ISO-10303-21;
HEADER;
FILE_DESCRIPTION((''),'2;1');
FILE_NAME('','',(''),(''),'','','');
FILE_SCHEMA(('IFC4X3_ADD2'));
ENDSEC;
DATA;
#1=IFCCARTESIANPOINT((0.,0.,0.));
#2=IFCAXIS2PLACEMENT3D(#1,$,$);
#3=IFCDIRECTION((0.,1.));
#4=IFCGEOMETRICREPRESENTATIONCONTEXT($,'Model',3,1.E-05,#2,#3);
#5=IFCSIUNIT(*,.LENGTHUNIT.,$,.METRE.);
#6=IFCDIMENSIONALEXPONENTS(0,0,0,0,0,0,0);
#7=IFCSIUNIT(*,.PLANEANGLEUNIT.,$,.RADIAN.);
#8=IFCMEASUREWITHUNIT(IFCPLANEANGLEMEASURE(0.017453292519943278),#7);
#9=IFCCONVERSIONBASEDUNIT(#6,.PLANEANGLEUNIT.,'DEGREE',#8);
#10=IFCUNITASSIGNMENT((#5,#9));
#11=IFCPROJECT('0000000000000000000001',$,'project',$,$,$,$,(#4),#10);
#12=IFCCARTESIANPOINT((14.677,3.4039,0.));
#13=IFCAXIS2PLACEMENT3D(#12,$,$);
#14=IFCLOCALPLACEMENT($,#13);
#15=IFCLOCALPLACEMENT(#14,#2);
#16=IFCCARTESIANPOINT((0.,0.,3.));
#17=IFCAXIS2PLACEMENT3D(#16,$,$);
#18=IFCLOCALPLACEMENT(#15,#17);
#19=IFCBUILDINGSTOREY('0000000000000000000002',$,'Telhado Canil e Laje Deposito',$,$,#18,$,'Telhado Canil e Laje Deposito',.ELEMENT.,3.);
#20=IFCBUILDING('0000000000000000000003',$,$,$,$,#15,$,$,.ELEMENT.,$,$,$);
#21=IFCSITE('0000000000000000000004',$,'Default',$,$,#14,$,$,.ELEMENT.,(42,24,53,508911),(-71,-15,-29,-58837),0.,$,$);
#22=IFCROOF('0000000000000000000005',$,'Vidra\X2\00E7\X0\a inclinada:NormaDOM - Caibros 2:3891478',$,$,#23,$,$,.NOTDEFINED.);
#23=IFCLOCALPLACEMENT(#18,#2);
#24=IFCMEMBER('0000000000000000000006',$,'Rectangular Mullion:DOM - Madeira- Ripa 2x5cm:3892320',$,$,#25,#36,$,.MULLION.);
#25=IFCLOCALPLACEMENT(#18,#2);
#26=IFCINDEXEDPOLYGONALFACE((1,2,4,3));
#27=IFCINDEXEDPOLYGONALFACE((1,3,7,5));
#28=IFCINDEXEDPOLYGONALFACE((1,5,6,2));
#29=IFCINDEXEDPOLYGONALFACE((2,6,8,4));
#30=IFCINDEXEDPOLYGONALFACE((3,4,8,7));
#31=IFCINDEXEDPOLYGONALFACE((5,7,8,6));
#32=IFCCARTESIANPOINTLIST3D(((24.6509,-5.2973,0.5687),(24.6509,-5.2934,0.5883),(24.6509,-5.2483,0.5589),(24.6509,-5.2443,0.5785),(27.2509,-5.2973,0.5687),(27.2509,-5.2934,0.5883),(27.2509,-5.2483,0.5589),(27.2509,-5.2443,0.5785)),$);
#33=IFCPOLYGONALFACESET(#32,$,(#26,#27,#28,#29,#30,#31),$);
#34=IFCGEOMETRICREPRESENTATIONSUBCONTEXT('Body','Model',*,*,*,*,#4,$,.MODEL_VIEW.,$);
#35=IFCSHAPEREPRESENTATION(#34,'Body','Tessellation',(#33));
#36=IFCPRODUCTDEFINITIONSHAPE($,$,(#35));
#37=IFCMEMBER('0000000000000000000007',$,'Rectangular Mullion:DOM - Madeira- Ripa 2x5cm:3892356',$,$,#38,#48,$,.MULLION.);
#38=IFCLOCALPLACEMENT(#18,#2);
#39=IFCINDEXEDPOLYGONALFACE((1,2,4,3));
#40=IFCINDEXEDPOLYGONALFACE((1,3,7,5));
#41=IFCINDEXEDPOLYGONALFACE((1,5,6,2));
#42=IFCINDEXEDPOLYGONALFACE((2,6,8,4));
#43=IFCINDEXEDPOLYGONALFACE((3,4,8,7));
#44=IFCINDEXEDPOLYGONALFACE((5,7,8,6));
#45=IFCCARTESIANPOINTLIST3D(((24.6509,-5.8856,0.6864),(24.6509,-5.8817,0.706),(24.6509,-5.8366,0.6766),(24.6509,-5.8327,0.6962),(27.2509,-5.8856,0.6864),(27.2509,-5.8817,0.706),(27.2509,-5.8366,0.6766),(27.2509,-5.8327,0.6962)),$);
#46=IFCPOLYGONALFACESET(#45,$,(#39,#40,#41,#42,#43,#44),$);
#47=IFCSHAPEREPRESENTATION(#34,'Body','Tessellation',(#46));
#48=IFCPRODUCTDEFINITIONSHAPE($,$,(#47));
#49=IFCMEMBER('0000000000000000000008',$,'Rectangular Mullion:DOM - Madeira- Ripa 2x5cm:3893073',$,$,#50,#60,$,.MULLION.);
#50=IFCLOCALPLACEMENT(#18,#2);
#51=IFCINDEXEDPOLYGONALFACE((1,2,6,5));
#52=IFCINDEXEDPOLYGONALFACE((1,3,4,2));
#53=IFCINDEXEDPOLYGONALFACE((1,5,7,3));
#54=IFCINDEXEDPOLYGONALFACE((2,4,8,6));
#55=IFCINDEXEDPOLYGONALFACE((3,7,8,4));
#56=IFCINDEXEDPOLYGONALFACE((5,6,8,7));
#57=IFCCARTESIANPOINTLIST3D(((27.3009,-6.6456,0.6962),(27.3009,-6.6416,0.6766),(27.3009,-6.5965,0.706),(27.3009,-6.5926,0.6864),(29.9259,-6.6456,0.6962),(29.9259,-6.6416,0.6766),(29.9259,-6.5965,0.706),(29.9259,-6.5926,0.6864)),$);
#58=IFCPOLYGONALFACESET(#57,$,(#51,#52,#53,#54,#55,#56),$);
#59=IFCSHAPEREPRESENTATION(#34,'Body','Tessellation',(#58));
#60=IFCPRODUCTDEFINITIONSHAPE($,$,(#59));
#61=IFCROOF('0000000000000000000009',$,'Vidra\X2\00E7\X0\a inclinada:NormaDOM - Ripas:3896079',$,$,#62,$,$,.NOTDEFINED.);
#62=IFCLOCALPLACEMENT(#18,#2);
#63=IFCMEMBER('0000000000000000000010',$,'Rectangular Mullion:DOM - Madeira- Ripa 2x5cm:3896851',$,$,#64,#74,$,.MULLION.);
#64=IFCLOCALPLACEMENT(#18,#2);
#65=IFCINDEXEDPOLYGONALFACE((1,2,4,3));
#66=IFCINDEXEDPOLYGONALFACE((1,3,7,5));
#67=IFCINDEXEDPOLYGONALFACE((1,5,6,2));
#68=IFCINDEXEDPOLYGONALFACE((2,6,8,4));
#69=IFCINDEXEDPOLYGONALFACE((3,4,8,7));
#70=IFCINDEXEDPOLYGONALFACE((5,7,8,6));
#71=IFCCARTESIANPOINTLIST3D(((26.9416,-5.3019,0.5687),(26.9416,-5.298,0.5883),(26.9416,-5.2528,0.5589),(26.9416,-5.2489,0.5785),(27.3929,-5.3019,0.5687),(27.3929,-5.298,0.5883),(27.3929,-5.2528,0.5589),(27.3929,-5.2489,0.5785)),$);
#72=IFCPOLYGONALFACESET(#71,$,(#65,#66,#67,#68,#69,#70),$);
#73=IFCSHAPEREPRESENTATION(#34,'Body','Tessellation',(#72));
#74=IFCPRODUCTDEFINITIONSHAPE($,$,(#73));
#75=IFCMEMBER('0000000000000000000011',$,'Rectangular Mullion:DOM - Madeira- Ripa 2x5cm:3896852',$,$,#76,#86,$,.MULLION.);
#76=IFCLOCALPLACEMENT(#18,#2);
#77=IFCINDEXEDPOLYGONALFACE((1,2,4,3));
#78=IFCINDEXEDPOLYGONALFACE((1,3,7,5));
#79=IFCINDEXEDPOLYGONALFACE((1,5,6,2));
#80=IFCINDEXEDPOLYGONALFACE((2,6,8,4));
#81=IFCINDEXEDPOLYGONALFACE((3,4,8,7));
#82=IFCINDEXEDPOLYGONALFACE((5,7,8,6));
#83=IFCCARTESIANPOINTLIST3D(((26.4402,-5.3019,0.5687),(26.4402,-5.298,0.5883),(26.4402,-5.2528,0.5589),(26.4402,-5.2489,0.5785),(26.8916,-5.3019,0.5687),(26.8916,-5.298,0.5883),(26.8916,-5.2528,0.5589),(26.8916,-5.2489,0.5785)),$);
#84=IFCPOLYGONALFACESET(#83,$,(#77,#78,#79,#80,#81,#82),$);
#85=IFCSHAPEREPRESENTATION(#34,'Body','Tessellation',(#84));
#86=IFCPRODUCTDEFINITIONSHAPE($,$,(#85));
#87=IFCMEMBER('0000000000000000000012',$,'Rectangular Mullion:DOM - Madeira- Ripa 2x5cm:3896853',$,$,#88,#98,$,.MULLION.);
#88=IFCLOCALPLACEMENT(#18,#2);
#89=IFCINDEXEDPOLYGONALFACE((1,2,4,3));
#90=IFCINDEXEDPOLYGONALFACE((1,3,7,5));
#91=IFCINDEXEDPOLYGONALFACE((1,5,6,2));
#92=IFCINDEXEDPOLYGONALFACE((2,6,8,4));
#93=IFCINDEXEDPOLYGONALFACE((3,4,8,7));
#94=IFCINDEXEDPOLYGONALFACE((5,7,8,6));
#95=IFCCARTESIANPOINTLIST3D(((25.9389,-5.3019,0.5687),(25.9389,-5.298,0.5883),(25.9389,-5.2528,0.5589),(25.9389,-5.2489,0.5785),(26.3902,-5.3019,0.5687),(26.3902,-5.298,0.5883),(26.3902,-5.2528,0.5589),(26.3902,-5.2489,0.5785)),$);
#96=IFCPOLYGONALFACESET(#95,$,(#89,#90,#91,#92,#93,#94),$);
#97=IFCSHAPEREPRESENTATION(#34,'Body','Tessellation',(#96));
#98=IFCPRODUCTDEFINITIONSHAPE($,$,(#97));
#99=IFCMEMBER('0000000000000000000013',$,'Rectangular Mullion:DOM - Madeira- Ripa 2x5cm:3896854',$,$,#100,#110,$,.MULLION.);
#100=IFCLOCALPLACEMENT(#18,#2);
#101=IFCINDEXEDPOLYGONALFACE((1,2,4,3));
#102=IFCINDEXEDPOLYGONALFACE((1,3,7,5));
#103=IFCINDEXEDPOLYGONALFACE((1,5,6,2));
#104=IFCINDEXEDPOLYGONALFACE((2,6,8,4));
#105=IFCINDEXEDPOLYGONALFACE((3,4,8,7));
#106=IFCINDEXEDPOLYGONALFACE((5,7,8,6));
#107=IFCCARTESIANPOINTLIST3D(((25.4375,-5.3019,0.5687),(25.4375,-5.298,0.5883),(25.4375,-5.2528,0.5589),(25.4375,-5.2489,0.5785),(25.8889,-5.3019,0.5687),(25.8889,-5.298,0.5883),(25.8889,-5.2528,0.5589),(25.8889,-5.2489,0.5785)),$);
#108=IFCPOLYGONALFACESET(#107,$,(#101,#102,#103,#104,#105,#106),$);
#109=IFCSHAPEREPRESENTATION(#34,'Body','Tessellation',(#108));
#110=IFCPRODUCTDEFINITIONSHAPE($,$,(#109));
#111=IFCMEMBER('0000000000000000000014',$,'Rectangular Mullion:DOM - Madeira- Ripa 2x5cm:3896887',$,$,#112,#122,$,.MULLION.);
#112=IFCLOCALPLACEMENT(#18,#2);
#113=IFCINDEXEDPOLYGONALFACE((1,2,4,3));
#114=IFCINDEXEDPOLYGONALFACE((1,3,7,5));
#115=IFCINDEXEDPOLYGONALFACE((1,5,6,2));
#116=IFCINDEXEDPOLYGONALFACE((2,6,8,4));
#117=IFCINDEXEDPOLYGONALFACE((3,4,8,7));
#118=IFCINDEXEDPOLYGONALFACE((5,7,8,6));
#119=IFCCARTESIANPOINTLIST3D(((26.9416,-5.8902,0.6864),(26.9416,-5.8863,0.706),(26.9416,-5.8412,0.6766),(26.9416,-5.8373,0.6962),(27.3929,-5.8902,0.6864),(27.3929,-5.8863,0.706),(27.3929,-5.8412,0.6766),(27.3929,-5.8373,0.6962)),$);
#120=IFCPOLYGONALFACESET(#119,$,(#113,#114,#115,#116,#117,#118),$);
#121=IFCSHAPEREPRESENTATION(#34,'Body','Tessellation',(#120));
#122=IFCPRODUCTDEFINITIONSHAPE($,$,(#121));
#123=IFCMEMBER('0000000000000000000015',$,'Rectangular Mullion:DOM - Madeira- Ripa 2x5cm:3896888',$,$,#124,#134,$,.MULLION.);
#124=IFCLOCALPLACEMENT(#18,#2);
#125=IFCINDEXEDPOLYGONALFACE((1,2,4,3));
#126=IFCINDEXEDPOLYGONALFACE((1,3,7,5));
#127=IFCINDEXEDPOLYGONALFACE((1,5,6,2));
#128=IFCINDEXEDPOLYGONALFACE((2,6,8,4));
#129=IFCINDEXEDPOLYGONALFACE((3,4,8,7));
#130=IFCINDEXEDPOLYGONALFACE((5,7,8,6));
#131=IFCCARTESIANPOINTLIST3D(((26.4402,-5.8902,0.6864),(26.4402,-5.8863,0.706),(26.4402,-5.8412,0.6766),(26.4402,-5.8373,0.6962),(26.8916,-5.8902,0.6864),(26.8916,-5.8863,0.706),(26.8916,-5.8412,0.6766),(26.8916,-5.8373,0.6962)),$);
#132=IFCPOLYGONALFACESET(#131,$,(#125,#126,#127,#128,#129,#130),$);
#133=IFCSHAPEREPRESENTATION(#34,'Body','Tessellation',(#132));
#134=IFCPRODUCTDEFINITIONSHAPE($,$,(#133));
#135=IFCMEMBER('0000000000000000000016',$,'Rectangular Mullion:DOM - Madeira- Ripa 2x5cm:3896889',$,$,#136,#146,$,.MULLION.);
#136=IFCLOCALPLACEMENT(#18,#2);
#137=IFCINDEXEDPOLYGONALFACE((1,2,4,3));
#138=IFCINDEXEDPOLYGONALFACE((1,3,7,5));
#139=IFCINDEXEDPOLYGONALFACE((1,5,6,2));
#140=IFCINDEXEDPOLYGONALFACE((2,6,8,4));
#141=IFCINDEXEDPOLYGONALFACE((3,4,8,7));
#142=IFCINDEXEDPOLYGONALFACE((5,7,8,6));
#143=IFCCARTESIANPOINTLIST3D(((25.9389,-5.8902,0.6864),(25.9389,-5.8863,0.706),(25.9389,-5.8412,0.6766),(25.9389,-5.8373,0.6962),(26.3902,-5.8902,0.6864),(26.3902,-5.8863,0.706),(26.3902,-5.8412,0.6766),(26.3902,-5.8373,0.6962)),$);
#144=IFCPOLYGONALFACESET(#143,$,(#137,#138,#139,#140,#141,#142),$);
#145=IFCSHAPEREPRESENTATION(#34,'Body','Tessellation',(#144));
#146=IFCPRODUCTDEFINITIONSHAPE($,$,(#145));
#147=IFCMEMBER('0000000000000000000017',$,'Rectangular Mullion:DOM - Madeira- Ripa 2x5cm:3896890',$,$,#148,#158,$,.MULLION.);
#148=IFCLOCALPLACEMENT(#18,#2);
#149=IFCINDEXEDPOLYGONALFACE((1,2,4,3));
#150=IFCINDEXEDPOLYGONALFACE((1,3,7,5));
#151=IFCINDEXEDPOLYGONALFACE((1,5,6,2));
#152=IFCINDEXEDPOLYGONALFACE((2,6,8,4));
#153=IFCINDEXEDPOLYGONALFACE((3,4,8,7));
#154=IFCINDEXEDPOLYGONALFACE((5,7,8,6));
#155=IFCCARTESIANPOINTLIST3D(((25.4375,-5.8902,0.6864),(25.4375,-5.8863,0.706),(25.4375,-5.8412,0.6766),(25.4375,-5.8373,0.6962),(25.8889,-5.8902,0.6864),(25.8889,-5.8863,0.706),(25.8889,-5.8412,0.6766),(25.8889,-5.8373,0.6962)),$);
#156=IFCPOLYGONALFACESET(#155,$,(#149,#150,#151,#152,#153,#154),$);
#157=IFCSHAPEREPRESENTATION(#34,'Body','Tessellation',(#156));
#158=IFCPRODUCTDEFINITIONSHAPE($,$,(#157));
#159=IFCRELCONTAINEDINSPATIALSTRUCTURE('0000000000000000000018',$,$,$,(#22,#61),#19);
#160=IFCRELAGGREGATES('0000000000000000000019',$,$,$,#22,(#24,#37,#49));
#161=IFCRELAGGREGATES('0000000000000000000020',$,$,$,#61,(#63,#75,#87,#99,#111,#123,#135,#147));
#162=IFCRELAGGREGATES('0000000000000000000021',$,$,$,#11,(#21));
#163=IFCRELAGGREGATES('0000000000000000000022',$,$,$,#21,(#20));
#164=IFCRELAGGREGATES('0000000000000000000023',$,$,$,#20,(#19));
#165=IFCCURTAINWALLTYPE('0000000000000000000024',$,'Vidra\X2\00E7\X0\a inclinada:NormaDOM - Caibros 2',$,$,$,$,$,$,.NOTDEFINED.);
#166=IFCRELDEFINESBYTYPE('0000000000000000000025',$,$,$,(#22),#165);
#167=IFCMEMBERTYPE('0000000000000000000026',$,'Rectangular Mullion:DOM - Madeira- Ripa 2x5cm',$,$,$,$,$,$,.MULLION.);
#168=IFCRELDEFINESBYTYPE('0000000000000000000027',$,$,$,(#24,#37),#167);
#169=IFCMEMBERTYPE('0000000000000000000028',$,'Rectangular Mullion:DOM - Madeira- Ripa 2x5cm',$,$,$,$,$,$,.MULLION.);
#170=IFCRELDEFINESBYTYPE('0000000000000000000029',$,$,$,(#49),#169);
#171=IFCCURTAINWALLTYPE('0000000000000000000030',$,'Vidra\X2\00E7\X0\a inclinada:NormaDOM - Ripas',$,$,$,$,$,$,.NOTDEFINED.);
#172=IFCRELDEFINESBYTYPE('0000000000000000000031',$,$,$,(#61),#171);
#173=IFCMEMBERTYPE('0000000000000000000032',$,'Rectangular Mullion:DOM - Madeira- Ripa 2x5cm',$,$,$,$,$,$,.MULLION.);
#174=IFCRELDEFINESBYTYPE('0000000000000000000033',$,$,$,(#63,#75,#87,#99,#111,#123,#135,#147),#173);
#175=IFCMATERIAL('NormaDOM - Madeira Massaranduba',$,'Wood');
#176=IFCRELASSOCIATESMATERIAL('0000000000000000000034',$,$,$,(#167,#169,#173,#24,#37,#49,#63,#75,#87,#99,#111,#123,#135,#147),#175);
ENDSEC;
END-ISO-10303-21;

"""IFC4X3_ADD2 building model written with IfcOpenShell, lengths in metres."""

from ifc_helpers import new_model, entity, si_unit, converted_unit, direction, frame, origin, origin_2d_with_axis, place, context, subcontext, project, spatial, rectangle, extrude, source, transform, mapped, material, material_profile, profile_set, profile_usage, type_object, type_shapes, element, aggregate, save


model = new_model("IFC4X3_ADD2")

# Units and contexts
model_context = context("Model", 3, precision=1e-05, world=origin(), true_north=direction((0.0, 1.0)))
body_context = subcontext(model_context, "Body", "Model", "MODEL_VIEW")
ifc_project = project(units=[si_unit("LENGTHUNIT", "METRE"), converted_unit("PLANEANGLEUNIT", "DEGREE", entity("IfcPlaneAngleMeasure", 0.017453292519943278), si_unit("PLANEANGLEUNIT", "RADIAN"), dimensions=[0, 0, 0, 0, 0, 0, 0])], contexts=[model_context])

# Site, building, storey
site_placement = place(None, frame((14.677, 3.4039, 0.0)))
site = spatial("IfcSite", under=ifc_project, at=site_placement, Name="Default", CompositionType="ELEMENT", RefLatitude=(42, 24, 53, 508911), RefLongitude=(-71, -15, -29, -58837), RefElevation=0.0)
building_placement = place(site_placement, origin())
building = spatial("IfcBuilding", under=site, at=building_placement, CompositionType="ELEMENT")
storey_placement = place(building_placement, frame((0.0, 0.0, 3.0)))
storey = spatial("IfcBuildingStorey", under=building, at=storey_placement, Name="Telhado Canil e Laje Deposito", LongName="Telhado Canil e Laje Deposito", CompositionType="ELEMENT", Elevation=3.0)

# Roofs, members
curtain_wall_type_1 = type_object("IfcCurtainWallType", Name="Vidraça inclinada:NormaDOM - Caibros 2", PredefinedType="NOTDEFINED")
roof_1_placement = place(storey_placement, frame((0.0, 0.0, -3.0)))
roof_1 = element("IfcRoof", 1, at=roof_1_placement, inside=storey, type_object=curtain_wall_type_1, Name="Vidraça inclinada:NormaDOM - Caibros 2:3891478", PredefinedType="NOTDEFINED")
ifc_material = material(Name="NormaDOM - Madeira Massaranduba", Category="Wood")
ifc_material_profile_1 = material_profile(ifc_material, rectangle(XDim=0.05, YDim=0.02, at=origin_2d_with_axis()), Name="DOM - Madeira- Ripa 2x5cm")
ifc_profile_set_1 = profile_set([ifc_material_profile_1], Name="DOM - Madeira- Ripa 2x5cm")
ifc_profile_usage_1 = profile_usage(ifc_profile_set_1)
member_type_1 = type_object("IfcMemberType", Name="Rectangular Mullion:DOM - Madeira- Ripa 2x5cm", PredefinedType="MULLION", material=ifc_profile_set_1)
shared_shape_1 = source(origin(), body_context, "Body", "SweptSolid", [
    extrude(rectangle(XDim=0.05, YDim=0.02, at=origin_2d_with_axis()), frame((0.025, 0.01, -2.6), z_axis=(0.0, 0.0, 1.0), x_axis=(-1.0, 0.0, 0.0)), (0.0, 0.0, 1.0), 2.6),
])
type_shapes(member_type_1, [shared_shape_1])
member_1_placement = place(roof_1_placement, frame((27.2509, -5.2443, 3.5785), z_axis=(1.0, 0.0, 0.0), x_axis=(0.0, -0.980581, 0.196116)))
member_1 = element("IfcMember", 2, at=member_1_placement, type_object=member_type_1, material=ifc_profile_usage_1, Name="Rectangular Mullion:DOM - Madeira- Ripa 2x5cm:3892320", PredefinedType="MULLION", context=body_context, shape_type="MappedRepresentation", body=[
    mapped(shared_shape_1, transform((0.0, 0.0, 0.0), scale=1.0)),
])
member_2_placement = place(roof_1_placement, frame((27.2509, -5.8327, 3.6962), z_axis=(1.0, 0.0, 0.0), x_axis=(0.0, -0.980581, 0.196116)))
member_2 = element("IfcMember", 3, at=member_2_placement, type_object=member_type_1, material=ifc_profile_usage_1, Name="Rectangular Mullion:DOM - Madeira- Ripa 2x5cm:3892356", PredefinedType="MULLION", context=body_context, shape_type="MappedRepresentation", body=[
    mapped(shared_shape_1, transform((0.0, 0.0, 0.0), scale=1.0)),
])
member_type_2 = type_object("IfcMemberType", Name="Rectangular Mullion:DOM - Madeira- Ripa 2x5cm", PredefinedType="MULLION", material=ifc_profile_set_1)
shared_shape_2 = source(origin(), body_context, "Body", "SweptSolid", [
    extrude(rectangle(XDim=0.05, YDim=0.02, at=origin_2d_with_axis()), frame((0.025, 0.01, -2.625), z_axis=(0.0, 0.0, 1.0), x_axis=(-1.0, 0.0, 0.0)), (0.0, 0.0, 1.0), 2.625),
])
type_shapes(member_type_2, [shared_shape_2])
member_3_placement = place(roof_1_placement, frame((27.3009, -6.6456, 3.6962), z_axis=(-1.0, 0.0, 0.0), x_axis=(0.0, 0.980581, 0.196116)))
member_3 = element("IfcMember", 4, at=member_3_placement, type_object=member_type_2, material=ifc_profile_usage_1, Name="Rectangular Mullion:DOM - Madeira- Ripa 2x5cm:3893073", PredefinedType="MULLION", context=body_context, shape_type="MappedRepresentation", body=[
    mapped(shared_shape_2, transform((0.0, 0.0, 0.0), scale=1.0)),
])
curtain_wall_type_2 = type_object("IfcCurtainWallType", Name="Vidraça inclinada:NormaDOM - Ripas", PredefinedType="NOTDEFINED")
roof_2_placement = place(storey_placement, frame((0.0, 0.0, -3.0)))
roof_2 = element("IfcRoof", 5, at=roof_2_placement, inside=storey, type_object=curtain_wall_type_2, Name="Vidraça inclinada:NormaDOM - Ripas:3896079", PredefinedType="NOTDEFINED")

# Members
aggregate(roof_1, [member_1, member_2, member_3])
member_type_3 = type_object("IfcMemberType", Name="Rectangular Mullion:DOM - Madeira- Ripa 2x5cm", PredefinedType="MULLION", material=ifc_profile_set_1)
shared_shape_3 = source(origin(), body_context, "Body", "SweptSolid", [
    extrude(rectangle(XDim=0.05, YDim=0.02, at=origin_2d_with_axis()), frame((0.025, 0.01, -0.4514), z_axis=(0.0, 0.0, 1.0), x_axis=(-1.0, 0.0, 0.0)), (0.0, 0.0, 1.0), 0.4514),
])
type_shapes(member_type_3, [shared_shape_3])
member_4_placement = place(roof_2_placement, frame((27.3929, -5.2489, 3.5785), z_axis=(1.0, 0.0, 0.0), x_axis=(0.0, -0.980581, 0.196116)))
member_4 = element("IfcMember", 6, at=member_4_placement, type_object=member_type_3, material=ifc_profile_usage_1, Name="Rectangular Mullion:DOM - Madeira- Ripa 2x5cm:3896851", PredefinedType="MULLION", context=body_context, shape_type="MappedRepresentation", body=[
    mapped(shared_shape_3, transform((0.0, 0.0, 0.0), scale=1.0)),
])
member_5_placement = place(roof_2_placement, frame((26.8916, -5.2489, 3.5785), z_axis=(1.0, 0.0, 0.0), x_axis=(0.0, -0.980581, 0.196116)))
member_5 = element("IfcMember", 7, at=member_5_placement, type_object=member_type_3, material=ifc_profile_usage_1, Name="Rectangular Mullion:DOM - Madeira- Ripa 2x5cm:3896852", PredefinedType="MULLION", context=body_context, shape_type="MappedRepresentation", body=[
    mapped(shared_shape_3, transform((0.0, 0.0, 0.0), scale=1.0)),
])
member_6_placement = place(roof_2_placement, frame((26.3902, -5.2489, 3.5785), z_axis=(1.0, 0.0, 0.0), x_axis=(0.0, -0.980581, 0.196116)))
member_6 = element("IfcMember", 8, at=member_6_placement, type_object=member_type_3, material=ifc_profile_usage_1, Name="Rectangular Mullion:DOM - Madeira- Ripa 2x5cm:3896853", PredefinedType="MULLION", context=body_context, shape_type="MappedRepresentation", body=[
    mapped(shared_shape_3, transform((0.0, 0.0, 0.0), scale=1.0)),
])
member_7_placement = place(roof_2_placement, frame((25.8889, -5.2489, 3.5785), z_axis=(1.0, 0.0, 0.0), x_axis=(0.0, -0.980581, 0.196116)))
member_7 = element("IfcMember", 9, at=member_7_placement, type_object=member_type_3, material=ifc_profile_usage_1, Name="Rectangular Mullion:DOM - Madeira- Ripa 2x5cm:3896854", PredefinedType="MULLION", context=body_context, shape_type="MappedRepresentation", body=[
    mapped(shared_shape_3, transform((0.0, 0.0, 0.0), scale=1.0)),
])
member_8_placement = place(roof_2_placement, frame((27.3929, -5.8373, 3.6962), z_axis=(1.0, 0.0, 0.0), x_axis=(0.0, -0.980581, 0.196116)))
member_8 = element("IfcMember", 10, at=member_8_placement, type_object=member_type_3, material=ifc_profile_usage_1, Name="Rectangular Mullion:DOM - Madeira- Ripa 2x5cm:3896887", PredefinedType="MULLION", context=body_context, shape_type="MappedRepresentation", body=[
    mapped(shared_shape_3, transform((0.0, 0.0, 0.0), scale=1.0)),
])
member_9_placement = place(roof_2_placement, frame((26.8916, -5.8373, 3.6962), z_axis=(1.0, 0.0, 0.0), x_axis=(0.0, -0.980581, 0.196116)))
member_9 = element("IfcMember", 11, at=member_9_placement, type_object=member_type_3, material=ifc_profile_usage_1, Name="Rectangular Mullion:DOM - Madeira- Ripa 2x5cm:3896888", PredefinedType="MULLION", context=body_context, shape_type="MappedRepresentation", body=[
    mapped(shared_shape_3, transform((0.0, 0.0, 0.0), scale=1.0)),
])
member_10_placement = place(roof_2_placement, frame((26.3902, -5.8373, 3.6962), z_axis=(1.0, 0.0, 0.0), x_axis=(0.0, -0.980581, 0.196116)))
member_10 = element("IfcMember", 12, at=member_10_placement, type_object=member_type_3, material=ifc_profile_usage_1, Name="Rectangular Mullion:DOM - Madeira- Ripa 2x5cm:3896889", PredefinedType="MULLION", context=body_context, shape_type="MappedRepresentation", body=[
    mapped(shared_shape_3, transform((0.0, 0.0, 0.0), scale=1.0)),
])
member_11_placement = place(roof_2_placement, frame((25.8889, -5.8373, 3.6962), z_axis=(1.0, 0.0, 0.0), x_axis=(0.0, -0.980581, 0.196116)))
member_11 = element("IfcMember", 13, at=member_11_placement, type_object=member_type_3, material=ifc_profile_usage_1, Name="Rectangular Mullion:DOM - Madeira- Ripa 2x5cm:3896890", PredefinedType="MULLION", context=body_context, shape_type="MappedRepresentation", body=[
    mapped(shared_shape_3, transform((0.0, 0.0, 0.0), scale=1.0)),
])
aggregate(roof_2, [member_4, member_5, member_6, member_7, member_8, member_9, member_10, member_11])

save(model, "model.ifc")
